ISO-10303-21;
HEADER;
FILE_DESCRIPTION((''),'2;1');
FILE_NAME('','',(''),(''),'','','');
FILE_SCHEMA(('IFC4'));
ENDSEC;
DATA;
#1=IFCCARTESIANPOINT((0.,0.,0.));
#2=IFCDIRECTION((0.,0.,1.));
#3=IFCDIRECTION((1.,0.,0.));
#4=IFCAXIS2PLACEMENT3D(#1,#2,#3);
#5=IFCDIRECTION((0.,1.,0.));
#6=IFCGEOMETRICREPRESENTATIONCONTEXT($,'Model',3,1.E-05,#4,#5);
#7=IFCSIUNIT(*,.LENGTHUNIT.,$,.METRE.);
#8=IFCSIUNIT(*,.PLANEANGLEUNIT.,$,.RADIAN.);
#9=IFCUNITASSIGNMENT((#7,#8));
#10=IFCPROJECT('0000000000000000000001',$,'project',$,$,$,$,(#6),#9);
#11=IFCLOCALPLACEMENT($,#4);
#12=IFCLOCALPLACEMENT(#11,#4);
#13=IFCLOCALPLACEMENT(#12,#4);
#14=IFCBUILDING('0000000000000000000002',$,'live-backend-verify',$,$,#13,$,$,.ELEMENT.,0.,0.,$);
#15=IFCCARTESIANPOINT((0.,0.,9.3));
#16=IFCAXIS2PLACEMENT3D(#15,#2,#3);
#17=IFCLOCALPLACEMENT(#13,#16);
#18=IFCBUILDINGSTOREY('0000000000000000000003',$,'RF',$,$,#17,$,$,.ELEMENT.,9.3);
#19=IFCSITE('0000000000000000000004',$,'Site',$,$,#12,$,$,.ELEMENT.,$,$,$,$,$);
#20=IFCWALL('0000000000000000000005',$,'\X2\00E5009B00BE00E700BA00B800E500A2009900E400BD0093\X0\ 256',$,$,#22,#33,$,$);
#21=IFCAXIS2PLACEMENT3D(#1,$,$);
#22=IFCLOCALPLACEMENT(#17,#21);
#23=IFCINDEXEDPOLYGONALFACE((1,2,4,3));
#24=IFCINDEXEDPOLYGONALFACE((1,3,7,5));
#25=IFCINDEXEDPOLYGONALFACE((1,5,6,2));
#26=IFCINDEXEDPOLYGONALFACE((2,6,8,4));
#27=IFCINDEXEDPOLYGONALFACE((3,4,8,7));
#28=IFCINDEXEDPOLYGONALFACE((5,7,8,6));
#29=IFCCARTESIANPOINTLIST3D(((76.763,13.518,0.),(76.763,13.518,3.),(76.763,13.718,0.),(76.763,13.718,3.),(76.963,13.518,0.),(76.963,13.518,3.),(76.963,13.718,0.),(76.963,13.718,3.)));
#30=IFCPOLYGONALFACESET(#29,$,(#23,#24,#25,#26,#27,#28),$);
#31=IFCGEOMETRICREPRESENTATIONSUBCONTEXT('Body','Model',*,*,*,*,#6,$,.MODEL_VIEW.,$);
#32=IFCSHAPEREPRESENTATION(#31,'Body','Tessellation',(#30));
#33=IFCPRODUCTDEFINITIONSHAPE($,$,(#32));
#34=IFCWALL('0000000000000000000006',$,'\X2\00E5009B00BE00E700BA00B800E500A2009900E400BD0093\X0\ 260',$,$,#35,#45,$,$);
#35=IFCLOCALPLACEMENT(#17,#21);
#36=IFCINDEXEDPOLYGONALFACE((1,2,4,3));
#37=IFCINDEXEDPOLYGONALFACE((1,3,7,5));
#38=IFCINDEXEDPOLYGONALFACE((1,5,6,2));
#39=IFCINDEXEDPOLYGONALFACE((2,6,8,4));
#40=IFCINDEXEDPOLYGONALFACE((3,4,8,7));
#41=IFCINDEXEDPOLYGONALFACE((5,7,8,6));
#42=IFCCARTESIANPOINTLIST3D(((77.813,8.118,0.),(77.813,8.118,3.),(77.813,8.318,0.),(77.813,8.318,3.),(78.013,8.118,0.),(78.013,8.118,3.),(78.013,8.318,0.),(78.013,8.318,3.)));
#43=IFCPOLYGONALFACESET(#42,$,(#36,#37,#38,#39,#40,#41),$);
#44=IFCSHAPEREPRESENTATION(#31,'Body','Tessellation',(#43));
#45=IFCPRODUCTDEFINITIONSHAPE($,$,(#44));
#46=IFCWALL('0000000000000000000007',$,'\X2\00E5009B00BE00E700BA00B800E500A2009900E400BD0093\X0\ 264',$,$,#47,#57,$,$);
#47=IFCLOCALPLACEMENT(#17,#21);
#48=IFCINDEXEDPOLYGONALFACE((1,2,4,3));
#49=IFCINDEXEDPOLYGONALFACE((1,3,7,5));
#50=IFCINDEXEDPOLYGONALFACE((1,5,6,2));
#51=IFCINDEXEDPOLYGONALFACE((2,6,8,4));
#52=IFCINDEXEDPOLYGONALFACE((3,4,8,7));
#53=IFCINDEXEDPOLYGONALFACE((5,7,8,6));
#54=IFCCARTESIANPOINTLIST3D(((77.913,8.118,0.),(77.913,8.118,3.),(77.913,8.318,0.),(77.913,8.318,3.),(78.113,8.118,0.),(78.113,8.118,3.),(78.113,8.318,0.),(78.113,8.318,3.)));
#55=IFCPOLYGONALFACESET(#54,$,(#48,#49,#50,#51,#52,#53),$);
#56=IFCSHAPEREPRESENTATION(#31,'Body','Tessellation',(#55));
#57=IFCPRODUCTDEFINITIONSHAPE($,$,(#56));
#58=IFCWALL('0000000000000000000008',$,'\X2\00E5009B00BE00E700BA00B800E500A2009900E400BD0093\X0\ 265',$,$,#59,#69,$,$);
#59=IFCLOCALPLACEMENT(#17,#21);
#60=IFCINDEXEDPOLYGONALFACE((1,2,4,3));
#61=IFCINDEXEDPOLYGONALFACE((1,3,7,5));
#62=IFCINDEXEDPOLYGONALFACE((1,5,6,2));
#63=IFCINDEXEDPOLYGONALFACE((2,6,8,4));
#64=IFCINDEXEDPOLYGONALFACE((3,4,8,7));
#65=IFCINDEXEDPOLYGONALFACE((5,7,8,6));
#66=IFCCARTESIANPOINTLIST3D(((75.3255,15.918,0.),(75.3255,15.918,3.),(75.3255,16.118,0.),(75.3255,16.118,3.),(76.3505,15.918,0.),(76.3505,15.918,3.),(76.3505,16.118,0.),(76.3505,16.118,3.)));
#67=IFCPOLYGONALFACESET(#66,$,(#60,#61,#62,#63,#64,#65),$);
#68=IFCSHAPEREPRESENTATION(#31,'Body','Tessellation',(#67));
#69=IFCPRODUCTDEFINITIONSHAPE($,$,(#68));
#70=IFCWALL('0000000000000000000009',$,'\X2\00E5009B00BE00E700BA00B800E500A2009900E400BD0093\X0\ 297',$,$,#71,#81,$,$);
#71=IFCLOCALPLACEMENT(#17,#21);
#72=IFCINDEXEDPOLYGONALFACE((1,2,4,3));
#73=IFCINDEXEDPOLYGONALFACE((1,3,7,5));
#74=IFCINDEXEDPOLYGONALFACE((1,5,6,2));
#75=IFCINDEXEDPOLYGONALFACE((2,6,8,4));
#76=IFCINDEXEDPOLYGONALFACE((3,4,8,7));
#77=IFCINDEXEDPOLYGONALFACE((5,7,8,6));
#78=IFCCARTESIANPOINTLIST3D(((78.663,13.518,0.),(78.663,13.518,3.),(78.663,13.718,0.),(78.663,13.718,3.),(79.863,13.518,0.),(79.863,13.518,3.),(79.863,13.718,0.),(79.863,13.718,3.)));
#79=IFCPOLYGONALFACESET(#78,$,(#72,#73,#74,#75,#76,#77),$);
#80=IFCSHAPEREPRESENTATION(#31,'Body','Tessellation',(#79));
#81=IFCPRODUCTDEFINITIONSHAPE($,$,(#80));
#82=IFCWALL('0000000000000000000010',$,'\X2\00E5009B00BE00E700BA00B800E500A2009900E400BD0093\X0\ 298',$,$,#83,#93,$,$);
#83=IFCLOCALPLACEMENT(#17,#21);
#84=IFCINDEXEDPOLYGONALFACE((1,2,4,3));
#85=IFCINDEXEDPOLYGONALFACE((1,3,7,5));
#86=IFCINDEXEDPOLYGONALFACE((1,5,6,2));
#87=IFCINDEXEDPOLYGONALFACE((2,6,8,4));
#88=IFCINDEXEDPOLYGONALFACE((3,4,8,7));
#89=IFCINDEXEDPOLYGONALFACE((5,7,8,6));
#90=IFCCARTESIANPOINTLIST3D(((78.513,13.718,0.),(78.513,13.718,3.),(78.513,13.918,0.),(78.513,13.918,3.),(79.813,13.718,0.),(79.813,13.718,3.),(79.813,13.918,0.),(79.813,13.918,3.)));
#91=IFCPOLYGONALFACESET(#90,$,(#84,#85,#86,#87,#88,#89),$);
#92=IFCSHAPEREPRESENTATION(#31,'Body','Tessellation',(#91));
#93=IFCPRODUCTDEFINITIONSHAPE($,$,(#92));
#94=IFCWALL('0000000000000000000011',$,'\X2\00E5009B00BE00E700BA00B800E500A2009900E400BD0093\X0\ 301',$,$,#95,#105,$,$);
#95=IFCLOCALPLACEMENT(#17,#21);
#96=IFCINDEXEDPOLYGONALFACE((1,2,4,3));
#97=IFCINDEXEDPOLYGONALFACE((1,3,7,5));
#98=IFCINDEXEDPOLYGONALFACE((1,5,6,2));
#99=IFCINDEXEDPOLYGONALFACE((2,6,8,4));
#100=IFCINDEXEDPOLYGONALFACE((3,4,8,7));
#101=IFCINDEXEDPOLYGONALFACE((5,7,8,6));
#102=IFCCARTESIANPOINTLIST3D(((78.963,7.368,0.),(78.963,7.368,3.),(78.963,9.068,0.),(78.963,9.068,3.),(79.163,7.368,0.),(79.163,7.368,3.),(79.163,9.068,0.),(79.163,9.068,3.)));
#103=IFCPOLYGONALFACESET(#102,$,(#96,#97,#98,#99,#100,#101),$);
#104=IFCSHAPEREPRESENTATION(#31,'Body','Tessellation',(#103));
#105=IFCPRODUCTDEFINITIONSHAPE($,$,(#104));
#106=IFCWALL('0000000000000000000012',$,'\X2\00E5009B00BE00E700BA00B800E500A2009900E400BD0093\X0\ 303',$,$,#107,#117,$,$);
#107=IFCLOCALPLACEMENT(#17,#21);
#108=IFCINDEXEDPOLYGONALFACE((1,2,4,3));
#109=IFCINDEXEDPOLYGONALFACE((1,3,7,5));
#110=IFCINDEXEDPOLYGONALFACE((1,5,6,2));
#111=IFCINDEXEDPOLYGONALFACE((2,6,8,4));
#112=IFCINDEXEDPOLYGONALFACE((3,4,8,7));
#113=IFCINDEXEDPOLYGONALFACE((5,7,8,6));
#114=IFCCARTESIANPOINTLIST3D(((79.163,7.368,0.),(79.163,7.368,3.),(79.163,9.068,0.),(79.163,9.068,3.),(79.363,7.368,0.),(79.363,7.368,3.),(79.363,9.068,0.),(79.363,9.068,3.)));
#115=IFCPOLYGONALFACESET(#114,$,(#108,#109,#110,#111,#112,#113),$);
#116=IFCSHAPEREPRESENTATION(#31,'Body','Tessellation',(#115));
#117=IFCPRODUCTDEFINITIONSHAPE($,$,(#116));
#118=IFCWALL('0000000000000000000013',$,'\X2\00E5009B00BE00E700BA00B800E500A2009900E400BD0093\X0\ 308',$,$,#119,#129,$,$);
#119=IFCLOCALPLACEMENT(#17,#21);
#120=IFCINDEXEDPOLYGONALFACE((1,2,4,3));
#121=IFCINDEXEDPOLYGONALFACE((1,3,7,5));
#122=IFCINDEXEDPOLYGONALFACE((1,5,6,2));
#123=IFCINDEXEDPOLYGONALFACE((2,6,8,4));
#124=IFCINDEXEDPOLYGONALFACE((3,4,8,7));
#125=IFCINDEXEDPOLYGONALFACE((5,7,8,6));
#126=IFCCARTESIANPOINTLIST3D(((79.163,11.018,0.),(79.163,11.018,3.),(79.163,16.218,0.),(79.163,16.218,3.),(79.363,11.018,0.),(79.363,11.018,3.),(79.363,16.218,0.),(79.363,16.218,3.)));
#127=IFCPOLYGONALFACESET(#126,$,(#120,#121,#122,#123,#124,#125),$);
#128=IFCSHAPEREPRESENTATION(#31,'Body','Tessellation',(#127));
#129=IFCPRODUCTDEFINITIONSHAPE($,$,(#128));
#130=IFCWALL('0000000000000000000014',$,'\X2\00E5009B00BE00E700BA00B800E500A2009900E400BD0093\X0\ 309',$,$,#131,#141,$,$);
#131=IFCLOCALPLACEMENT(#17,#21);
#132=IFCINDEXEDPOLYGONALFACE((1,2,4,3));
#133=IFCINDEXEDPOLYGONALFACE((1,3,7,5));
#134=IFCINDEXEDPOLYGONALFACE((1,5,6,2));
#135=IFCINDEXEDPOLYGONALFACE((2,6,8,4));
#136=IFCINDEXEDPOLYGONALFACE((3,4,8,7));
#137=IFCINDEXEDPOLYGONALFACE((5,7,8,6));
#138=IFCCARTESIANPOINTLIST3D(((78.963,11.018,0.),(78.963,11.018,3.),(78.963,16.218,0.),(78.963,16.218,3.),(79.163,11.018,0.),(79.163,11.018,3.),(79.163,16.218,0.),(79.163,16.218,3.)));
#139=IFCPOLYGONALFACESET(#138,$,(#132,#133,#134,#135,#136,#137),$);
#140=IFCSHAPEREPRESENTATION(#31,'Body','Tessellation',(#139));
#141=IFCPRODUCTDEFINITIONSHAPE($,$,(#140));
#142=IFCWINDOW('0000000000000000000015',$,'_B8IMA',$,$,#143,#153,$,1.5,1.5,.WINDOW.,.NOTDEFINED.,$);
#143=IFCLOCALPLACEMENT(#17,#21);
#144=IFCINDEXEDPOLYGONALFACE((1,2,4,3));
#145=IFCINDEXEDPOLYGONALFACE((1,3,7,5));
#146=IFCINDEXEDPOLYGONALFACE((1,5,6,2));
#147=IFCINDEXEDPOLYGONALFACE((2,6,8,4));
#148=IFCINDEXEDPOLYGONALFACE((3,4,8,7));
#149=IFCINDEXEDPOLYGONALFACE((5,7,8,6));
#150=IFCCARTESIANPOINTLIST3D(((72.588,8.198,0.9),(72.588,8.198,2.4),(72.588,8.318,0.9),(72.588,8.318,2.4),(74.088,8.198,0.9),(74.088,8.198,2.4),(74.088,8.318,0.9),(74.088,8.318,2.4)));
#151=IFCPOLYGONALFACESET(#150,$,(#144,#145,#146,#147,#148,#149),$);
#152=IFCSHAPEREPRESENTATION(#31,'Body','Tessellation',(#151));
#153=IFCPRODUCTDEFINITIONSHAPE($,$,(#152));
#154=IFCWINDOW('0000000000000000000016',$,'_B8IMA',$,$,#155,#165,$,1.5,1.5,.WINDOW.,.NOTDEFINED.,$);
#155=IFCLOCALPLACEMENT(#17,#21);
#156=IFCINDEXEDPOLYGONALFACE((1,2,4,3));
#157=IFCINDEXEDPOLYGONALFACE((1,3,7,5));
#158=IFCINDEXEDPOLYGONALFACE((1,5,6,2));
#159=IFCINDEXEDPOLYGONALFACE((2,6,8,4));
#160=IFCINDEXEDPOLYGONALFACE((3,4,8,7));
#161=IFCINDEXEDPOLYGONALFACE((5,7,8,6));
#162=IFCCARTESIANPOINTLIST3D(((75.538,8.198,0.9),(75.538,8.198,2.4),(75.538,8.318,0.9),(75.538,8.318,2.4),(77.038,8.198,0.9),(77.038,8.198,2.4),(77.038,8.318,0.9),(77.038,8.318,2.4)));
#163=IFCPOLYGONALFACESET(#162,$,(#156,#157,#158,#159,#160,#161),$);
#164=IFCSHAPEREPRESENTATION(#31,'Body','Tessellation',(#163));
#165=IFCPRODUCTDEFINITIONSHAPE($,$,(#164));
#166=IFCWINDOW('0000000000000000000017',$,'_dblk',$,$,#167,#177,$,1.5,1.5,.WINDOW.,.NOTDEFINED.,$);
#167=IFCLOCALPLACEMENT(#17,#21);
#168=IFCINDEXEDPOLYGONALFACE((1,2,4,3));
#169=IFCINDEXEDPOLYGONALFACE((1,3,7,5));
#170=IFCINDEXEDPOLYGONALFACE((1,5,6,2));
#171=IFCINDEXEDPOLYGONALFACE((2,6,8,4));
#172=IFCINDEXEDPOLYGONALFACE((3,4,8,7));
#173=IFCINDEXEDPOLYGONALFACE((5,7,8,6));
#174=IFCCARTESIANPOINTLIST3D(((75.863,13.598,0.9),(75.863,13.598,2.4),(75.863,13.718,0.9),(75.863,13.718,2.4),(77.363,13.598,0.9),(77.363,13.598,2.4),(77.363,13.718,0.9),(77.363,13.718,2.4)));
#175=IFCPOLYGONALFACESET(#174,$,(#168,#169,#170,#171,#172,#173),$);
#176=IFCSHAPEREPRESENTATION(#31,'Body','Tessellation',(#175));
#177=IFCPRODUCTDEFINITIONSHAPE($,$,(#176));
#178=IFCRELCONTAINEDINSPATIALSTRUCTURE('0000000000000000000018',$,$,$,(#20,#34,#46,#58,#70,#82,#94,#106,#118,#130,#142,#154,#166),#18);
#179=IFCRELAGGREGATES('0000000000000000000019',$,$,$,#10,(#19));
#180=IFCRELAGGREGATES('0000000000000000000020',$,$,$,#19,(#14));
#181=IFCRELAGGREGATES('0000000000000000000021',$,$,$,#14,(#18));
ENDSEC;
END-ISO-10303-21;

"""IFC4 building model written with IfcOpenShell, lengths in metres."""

from ifc_helpers import new_model, si_unit, direction, frame, frame_2d, origin_with_axes, place, context, subcontext, project, spatial, rectangle, extrude, element, save


model = new_model("IFC4")

# Units and contexts
model_context = context("Model", 3, precision=1e-05, world=origin_with_axes(), true_north=direction((0.0, 1.0, 0.0)))
body_context = subcontext(model_context, "Body", "Model", "MODEL_VIEW")
ifc_project = project(units=[si_unit("LENGTHUNIT", "METRE"), si_unit("PLANEANGLEUNIT", "RADIAN")], contexts=[model_context])

# Site, building, storey
placement = place(None, origin_with_axes())
site_placement = place(placement, origin_with_axes())
site = spatial("IfcSite", under=ifc_project, at=site_placement, Name="Site", CompositionType="ELEMENT")
building_placement = place(site_placement, origin_with_axes())
building = spatial("IfcBuilding", under=site, at=building_placement, Name="live-backend-verify", CompositionType="ELEMENT", ElevationOfRefHeight=0.0, ElevationOfTerrain=0.0)
storey_placement = place(building_placement, frame((0.0, 0.0, 9.3), z_axis=(0.0, 0.0, 1.0), x_axis=(1.0, 0.0, 0.0)))
storey = spatial("IfcBuildingStorey", under=building, at=storey_placement, Name="RF", CompositionType="ELEMENT", Elevation=9.3)

# Walls
for number, where, z_axis, x_axis, name in (
    (1, (76.863, 13.618, 0.0), (0.0, 0.0, 1.0), (0.0, 1.0, 0.0), "å\u009b¾çº¸å¢\u0099ä½\u0093 256"),
    (2, (77.913, 8.218, 0.0), (0.0, 0.0, 1.0), (0.0, 1.0, 0.0), "å\u009b¾çº¸å¢\u0099ä½\u0093 260"),
    (3, (78.013, 8.218, 0.0), (0.0, 0.0, 1.0), (0.0, -1.0, 0.0), "å\u009b¾çº¸å¢\u0099ä½\u0093 264"),
):
    element("IfcWall", number, at=place(storey_placement, frame(where, z_axis=z_axis, x_axis=x_axis)), inside=storey, Name=name, context=body_context, shape_type="SweptSolid", body=[
        extrude(rectangle(XDim=0.2, YDim=0.2, at=frame_2d((0.0, 0.0), x_axis=(1.0, 0.0, 0.0))), frame((0.0, 0.0, 0.0), z_axis=(0.0, 0.0, 1.0)), (0.0, 0.0, 1.0), 3.0),
    ])
wall_1_placement = place(storey_placement, frame((75.838, 16.018, 0.0), z_axis=(0.0, 0.0, 1.0), x_axis=(1.0, 0.0, 0.0)))
element("IfcWall", 4, at=wall_1_placement, inside=storey, Name="å\u009b¾çº¸å¢\u0099ä½\u0093 265", context=body_context, shape_type="SweptSolid", body=[
    extrude(rectangle(XDim=1.025, YDim=0.2, at=frame_2d((0.0, 0.0), x_axis=(1.0, 0.0, 0.0))), frame((0.0, 0.0, 0.0), z_axis=(0.0, 0.0, 1.0)), (0.0, 0.0, 1.0), 3.0),
])
wall_2_placement = place(storey_placement, frame((79.263, 13.618, 0.0), z_axis=(0.0, 0.0, 1.0), x_axis=(1.0, 0.0, 0.0)))
element("IfcWall", 5, at=wall_2_placement, inside=storey, Name="å\u009b¾çº¸å¢\u0099ä½\u0093 297", context=body_context, shape_type="SweptSolid", body=[
    extrude(rectangle(XDim=1.2, YDim=0.2, at=frame_2d((0.0, 0.0), x_axis=(1.0, 0.0, 0.0))), frame((0.0, 0.0, 0.0), z_axis=(0.0, 0.0, 1.0)), (0.0, 0.0, 1.0), 3.0),
])
wall_3_placement = place(storey_placement, frame((79.163, 13.818, 0.0), z_axis=(0.0, 0.0, 1.0), x_axis=(1.0, 0.0, 0.0)))
element("IfcWall", 6, at=wall_3_placement, inside=storey, Name="å\u009b¾çº¸å¢\u0099ä½\u0093 298", context=body_context, shape_type="SweptSolid", body=[
    extrude(rectangle(XDim=1.3, YDim=0.2, at=frame_2d((0.0, 0.0), x_axis=(1.0, 0.0, 0.0))), frame((0.0, 0.0, 0.0), z_axis=(0.0, 0.0, 1.0)), (0.0, 0.0, 1.0), 3.0),
])
for number, where, z_axis, x_axis, name in (
    (7, (79.063, 8.218, 0.0), (0.0, 0.0, 1.0), (0.0, -1.0, 0.0), "å\u009b¾çº¸å¢\u0099ä½\u0093 301"),
    (8, (79.263, 8.218, 0.0), (0.0, 0.0, 1.0), (0.0, -1.0, 0.0), "å\u009b¾çº¸å¢\u0099ä½\u0093 303"),
):
    element("IfcWall", number, at=place(storey_placement, frame(where, z_axis=z_axis, x_axis=x_axis)), inside=storey, Name=name, context=body_context, shape_type="SweptSolid", body=[
        extrude(rectangle(XDim=1.7, YDim=0.2, at=frame_2d((0.0, 0.0), x_axis=(1.0, 0.0, 0.0))), frame((0.0, 0.0, 0.0), z_axis=(0.0, 0.0, 1.0)), (0.0, 0.0, 1.0), 3.0),
    ])
for number, where, z_axis, x_axis, name in (
    (9, (79.263, 13.618, 0.0), (0.0, 0.0, 1.0), (0.0, -1.0, 0.0), "å\u009b¾çº¸å¢\u0099ä½\u0093 308"),
    (10, (79.063, 13.618, 0.0), (0.0, 0.0, 1.0), (0.0, -1.0, 0.0), "å\u009b¾çº¸å¢\u0099ä½\u0093 309"),
):
    element("IfcWall", number, at=place(storey_placement, frame(where, z_axis=z_axis, x_axis=x_axis)), inside=storey, Name=name, context=body_context, shape_type="SweptSolid", body=[
        extrude(rectangle(XDim=5.2, YDim=0.2, at=frame_2d((0.0, 0.0), x_axis=(1.0, 0.0, 0.0))), frame((0.0, 0.0, 0.0), z_axis=(0.0, 0.0, 1.0)), (0.0, 0.0, 1.0), 3.0),
    ])

# Windows
for number, where, z_axis, x_axis, name in (
    (11, (73.338, 8.258, 0.9), (0.0, 0.0, 1.0), (1.0, 0.0, 0.0), "_B8IMA"),
    (12, (76.288, 8.258, 0.9), (0.0, 0.0, 1.0), (1.0, 0.0, 0.0), "_B8IMA"),
    (13, (76.613, 13.658, 0.9), (0.0, 0.0, 1.0), (1.0, 0.0, 0.0), "_dblk"),
):
    element("IfcWindow", number, at=place(storey_placement, frame(where, z_axis=z_axis, x_axis=x_axis)), inside=storey, Name=name, OverallHeight=1.5, OverallWidth=1.5, PartitioningType="NOTDEFINED", PredefinedType="WINDOW", context=body_context, shape_type="SweptSolid", body=[
        extrude(rectangle(XDim=1.5, YDim=0.12, at=frame_2d((0.0, 0.0), x_axis=(1.0, 0.0, 0.0))), frame((0.0, 0.0, 0.0), z_axis=(0.0, 0.0, 1.0)), (0.0, 0.0, 1.0), 1.5),
    ])

save(model, "model.ifc")
